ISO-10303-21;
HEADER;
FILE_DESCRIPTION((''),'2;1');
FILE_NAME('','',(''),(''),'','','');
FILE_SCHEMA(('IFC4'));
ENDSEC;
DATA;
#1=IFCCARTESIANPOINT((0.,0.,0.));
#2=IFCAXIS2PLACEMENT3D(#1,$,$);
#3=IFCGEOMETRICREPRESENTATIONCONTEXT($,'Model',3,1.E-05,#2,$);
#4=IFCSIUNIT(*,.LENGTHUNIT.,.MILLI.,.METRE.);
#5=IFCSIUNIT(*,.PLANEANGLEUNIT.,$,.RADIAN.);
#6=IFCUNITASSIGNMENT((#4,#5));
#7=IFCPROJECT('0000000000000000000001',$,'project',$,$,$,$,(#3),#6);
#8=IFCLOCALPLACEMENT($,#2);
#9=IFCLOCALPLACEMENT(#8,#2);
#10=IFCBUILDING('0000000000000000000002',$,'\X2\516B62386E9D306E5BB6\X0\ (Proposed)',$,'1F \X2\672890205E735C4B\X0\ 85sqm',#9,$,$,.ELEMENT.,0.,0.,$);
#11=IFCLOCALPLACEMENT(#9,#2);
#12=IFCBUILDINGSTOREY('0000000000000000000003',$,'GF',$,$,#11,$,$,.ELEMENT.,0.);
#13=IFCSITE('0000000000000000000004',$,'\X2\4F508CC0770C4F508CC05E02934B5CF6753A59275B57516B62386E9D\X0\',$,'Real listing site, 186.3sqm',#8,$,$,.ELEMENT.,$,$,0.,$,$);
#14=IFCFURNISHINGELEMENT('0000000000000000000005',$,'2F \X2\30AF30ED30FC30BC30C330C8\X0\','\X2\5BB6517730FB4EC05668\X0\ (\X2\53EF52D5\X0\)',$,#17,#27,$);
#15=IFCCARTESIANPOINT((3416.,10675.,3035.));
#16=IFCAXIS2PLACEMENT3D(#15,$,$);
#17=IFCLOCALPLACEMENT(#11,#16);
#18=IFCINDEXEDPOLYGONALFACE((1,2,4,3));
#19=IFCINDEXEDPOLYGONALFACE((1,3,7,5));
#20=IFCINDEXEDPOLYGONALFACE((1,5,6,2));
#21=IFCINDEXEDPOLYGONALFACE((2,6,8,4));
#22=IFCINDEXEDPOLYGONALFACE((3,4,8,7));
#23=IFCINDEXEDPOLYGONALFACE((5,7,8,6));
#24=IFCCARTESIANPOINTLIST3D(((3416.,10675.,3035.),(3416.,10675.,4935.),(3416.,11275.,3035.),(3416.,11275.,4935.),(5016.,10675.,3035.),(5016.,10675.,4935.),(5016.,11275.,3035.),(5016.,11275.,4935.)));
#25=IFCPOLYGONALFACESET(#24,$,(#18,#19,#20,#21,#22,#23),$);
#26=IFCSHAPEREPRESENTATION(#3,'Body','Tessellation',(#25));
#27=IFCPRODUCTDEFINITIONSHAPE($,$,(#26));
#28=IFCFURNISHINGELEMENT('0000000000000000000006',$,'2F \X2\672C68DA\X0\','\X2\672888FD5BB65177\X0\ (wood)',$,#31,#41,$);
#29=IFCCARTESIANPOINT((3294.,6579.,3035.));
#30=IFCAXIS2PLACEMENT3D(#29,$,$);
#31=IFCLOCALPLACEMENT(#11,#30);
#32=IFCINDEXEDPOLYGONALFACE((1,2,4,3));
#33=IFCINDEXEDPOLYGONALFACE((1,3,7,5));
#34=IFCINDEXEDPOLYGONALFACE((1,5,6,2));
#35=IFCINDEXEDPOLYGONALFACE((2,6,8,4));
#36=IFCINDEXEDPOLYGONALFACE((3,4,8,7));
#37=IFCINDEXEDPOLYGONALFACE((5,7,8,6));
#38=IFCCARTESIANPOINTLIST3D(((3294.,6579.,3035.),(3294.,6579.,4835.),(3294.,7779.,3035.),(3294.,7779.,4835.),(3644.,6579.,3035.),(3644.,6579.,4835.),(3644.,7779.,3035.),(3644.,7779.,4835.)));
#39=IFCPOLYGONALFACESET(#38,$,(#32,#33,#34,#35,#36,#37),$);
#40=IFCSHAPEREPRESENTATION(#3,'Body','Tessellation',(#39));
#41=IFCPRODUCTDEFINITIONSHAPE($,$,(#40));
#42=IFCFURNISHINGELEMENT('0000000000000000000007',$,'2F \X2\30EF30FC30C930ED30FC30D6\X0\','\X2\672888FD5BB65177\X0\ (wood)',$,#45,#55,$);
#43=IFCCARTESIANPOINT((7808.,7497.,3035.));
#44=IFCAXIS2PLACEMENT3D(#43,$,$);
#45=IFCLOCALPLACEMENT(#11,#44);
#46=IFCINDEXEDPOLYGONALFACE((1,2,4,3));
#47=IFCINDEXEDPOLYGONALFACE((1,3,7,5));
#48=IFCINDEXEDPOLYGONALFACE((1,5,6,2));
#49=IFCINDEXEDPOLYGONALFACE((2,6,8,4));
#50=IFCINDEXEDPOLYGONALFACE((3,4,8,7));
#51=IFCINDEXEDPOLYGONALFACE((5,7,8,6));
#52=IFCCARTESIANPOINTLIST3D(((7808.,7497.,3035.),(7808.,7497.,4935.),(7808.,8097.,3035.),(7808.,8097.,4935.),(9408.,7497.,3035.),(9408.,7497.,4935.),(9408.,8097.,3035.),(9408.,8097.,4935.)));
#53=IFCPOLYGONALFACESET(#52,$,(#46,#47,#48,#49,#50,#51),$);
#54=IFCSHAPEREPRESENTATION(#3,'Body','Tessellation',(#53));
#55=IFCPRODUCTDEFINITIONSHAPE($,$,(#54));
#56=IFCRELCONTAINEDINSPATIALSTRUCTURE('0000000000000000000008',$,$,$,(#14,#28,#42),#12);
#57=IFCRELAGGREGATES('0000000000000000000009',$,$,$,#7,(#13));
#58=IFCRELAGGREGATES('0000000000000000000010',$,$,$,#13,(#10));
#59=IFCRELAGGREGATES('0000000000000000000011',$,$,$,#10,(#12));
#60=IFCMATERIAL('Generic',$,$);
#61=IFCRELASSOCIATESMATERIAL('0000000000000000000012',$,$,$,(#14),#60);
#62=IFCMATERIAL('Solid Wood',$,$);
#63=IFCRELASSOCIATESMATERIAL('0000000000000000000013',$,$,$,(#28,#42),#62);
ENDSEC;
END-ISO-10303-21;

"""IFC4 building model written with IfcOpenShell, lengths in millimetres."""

from ifc_helpers import new_model, si_unit, frame, frame_2d, origin, place, context, project, spatial, rectangle, extrude, material, element, save


model = new_model("IFC4")

# Units and contexts
model_context = context("Model", 3, precision=1e-05, world=origin())
ifc_project = project(units=[si_unit("LENGTHUNIT", "METRE", prefix="MILLI"), si_unit("PLANEANGLEUNIT", "RADIAN")], contexts=[model_context])

# Site, building, storey
site_placement = place(None, origin())
site = spatial("IfcSite", under=ifc_project, at=site_placement, Name="佐賀県佐賀市鍋島町大字八戸溝", ObjectType="Real listing site, 186.3sqm", CompositionType="ELEMENT", RefElevation=0.0)
building_placement = place(site_placement, origin())
building = spatial("IfcBuilding", under=site, at=building_placement, Name="八戸溝の家 (Proposed)", ObjectType="1F 木造平屋 85sqm", CompositionType="ELEMENT", ElevationOfRefHeight=0.0, ElevationOfTerrain=0.0)
storey_placement = place(building_placement, origin())
storey = spatial("IfcBuildingStorey", under=building, at=storey_placement, Name="GF", CompositionType="ELEMENT", Elevation=0.0)

# Shared definitions
ifc_material_1 = material(Name="Solid Wood")

# Shared definitions
ifc_material_2 = material(Name="Generic")

# Furnishing elements
furnishing_1_placement = place(storey_placement, frame((3416.0, 10675.0, 3035.0)))
element("IfcFurnishingElement", 1, at=furnishing_1_placement, inside=storey, material=ifc_material_2, Name="2F クローゼット", Description="家具・什器 (可動)", context=model_context, shape_type="SweptSolid", body=[
    extrude(rectangle(XDim=1600.0, YDim=600.0, at=frame_2d((800.0, 300.0))), frame((3416.0, 10675.0, 3035.0)), (0.0, 0.0, 1.0), 1900.0),
])
furnishing_2_placement = place(storey_placement, frame((3294.0, 6579.0, 3035.0)))
element("IfcFurnishingElement", 2, at=furnishing_2_placement, inside=storey, material=ifc_material_1, Name="2F 本棚", Description="木製家具 (wood)", context=model_context, shape_type="SweptSolid", body=[
    extrude(rectangle(XDim=350.0, YDim=1200.0, at=frame_2d((175.0, 600.0))), frame((3294.0, 6579.0, 3035.0)), (0.0, 0.0, 1.0), 1800.0),
])
furnishing_3_placement = place(storey_placement, frame((7808.0, 7497.0, 3035.0)))
element("IfcFurnishingElement", 3, at=furnishing_3_placement, inside=storey, material=ifc_material_1, Name="2F ワードローブ", Description="木製家具 (wood)", context=model_context, shape_type="SweptSolid", body=[
    extrude(rectangle(XDim=1600.0, YDim=600.0, at=frame_2d((800.0, 300.0))), frame((7808.0, 7497.0, 3035.0)), (0.0, 0.0, 1.0), 1900.0),
])

save(model, "model.ifc")
